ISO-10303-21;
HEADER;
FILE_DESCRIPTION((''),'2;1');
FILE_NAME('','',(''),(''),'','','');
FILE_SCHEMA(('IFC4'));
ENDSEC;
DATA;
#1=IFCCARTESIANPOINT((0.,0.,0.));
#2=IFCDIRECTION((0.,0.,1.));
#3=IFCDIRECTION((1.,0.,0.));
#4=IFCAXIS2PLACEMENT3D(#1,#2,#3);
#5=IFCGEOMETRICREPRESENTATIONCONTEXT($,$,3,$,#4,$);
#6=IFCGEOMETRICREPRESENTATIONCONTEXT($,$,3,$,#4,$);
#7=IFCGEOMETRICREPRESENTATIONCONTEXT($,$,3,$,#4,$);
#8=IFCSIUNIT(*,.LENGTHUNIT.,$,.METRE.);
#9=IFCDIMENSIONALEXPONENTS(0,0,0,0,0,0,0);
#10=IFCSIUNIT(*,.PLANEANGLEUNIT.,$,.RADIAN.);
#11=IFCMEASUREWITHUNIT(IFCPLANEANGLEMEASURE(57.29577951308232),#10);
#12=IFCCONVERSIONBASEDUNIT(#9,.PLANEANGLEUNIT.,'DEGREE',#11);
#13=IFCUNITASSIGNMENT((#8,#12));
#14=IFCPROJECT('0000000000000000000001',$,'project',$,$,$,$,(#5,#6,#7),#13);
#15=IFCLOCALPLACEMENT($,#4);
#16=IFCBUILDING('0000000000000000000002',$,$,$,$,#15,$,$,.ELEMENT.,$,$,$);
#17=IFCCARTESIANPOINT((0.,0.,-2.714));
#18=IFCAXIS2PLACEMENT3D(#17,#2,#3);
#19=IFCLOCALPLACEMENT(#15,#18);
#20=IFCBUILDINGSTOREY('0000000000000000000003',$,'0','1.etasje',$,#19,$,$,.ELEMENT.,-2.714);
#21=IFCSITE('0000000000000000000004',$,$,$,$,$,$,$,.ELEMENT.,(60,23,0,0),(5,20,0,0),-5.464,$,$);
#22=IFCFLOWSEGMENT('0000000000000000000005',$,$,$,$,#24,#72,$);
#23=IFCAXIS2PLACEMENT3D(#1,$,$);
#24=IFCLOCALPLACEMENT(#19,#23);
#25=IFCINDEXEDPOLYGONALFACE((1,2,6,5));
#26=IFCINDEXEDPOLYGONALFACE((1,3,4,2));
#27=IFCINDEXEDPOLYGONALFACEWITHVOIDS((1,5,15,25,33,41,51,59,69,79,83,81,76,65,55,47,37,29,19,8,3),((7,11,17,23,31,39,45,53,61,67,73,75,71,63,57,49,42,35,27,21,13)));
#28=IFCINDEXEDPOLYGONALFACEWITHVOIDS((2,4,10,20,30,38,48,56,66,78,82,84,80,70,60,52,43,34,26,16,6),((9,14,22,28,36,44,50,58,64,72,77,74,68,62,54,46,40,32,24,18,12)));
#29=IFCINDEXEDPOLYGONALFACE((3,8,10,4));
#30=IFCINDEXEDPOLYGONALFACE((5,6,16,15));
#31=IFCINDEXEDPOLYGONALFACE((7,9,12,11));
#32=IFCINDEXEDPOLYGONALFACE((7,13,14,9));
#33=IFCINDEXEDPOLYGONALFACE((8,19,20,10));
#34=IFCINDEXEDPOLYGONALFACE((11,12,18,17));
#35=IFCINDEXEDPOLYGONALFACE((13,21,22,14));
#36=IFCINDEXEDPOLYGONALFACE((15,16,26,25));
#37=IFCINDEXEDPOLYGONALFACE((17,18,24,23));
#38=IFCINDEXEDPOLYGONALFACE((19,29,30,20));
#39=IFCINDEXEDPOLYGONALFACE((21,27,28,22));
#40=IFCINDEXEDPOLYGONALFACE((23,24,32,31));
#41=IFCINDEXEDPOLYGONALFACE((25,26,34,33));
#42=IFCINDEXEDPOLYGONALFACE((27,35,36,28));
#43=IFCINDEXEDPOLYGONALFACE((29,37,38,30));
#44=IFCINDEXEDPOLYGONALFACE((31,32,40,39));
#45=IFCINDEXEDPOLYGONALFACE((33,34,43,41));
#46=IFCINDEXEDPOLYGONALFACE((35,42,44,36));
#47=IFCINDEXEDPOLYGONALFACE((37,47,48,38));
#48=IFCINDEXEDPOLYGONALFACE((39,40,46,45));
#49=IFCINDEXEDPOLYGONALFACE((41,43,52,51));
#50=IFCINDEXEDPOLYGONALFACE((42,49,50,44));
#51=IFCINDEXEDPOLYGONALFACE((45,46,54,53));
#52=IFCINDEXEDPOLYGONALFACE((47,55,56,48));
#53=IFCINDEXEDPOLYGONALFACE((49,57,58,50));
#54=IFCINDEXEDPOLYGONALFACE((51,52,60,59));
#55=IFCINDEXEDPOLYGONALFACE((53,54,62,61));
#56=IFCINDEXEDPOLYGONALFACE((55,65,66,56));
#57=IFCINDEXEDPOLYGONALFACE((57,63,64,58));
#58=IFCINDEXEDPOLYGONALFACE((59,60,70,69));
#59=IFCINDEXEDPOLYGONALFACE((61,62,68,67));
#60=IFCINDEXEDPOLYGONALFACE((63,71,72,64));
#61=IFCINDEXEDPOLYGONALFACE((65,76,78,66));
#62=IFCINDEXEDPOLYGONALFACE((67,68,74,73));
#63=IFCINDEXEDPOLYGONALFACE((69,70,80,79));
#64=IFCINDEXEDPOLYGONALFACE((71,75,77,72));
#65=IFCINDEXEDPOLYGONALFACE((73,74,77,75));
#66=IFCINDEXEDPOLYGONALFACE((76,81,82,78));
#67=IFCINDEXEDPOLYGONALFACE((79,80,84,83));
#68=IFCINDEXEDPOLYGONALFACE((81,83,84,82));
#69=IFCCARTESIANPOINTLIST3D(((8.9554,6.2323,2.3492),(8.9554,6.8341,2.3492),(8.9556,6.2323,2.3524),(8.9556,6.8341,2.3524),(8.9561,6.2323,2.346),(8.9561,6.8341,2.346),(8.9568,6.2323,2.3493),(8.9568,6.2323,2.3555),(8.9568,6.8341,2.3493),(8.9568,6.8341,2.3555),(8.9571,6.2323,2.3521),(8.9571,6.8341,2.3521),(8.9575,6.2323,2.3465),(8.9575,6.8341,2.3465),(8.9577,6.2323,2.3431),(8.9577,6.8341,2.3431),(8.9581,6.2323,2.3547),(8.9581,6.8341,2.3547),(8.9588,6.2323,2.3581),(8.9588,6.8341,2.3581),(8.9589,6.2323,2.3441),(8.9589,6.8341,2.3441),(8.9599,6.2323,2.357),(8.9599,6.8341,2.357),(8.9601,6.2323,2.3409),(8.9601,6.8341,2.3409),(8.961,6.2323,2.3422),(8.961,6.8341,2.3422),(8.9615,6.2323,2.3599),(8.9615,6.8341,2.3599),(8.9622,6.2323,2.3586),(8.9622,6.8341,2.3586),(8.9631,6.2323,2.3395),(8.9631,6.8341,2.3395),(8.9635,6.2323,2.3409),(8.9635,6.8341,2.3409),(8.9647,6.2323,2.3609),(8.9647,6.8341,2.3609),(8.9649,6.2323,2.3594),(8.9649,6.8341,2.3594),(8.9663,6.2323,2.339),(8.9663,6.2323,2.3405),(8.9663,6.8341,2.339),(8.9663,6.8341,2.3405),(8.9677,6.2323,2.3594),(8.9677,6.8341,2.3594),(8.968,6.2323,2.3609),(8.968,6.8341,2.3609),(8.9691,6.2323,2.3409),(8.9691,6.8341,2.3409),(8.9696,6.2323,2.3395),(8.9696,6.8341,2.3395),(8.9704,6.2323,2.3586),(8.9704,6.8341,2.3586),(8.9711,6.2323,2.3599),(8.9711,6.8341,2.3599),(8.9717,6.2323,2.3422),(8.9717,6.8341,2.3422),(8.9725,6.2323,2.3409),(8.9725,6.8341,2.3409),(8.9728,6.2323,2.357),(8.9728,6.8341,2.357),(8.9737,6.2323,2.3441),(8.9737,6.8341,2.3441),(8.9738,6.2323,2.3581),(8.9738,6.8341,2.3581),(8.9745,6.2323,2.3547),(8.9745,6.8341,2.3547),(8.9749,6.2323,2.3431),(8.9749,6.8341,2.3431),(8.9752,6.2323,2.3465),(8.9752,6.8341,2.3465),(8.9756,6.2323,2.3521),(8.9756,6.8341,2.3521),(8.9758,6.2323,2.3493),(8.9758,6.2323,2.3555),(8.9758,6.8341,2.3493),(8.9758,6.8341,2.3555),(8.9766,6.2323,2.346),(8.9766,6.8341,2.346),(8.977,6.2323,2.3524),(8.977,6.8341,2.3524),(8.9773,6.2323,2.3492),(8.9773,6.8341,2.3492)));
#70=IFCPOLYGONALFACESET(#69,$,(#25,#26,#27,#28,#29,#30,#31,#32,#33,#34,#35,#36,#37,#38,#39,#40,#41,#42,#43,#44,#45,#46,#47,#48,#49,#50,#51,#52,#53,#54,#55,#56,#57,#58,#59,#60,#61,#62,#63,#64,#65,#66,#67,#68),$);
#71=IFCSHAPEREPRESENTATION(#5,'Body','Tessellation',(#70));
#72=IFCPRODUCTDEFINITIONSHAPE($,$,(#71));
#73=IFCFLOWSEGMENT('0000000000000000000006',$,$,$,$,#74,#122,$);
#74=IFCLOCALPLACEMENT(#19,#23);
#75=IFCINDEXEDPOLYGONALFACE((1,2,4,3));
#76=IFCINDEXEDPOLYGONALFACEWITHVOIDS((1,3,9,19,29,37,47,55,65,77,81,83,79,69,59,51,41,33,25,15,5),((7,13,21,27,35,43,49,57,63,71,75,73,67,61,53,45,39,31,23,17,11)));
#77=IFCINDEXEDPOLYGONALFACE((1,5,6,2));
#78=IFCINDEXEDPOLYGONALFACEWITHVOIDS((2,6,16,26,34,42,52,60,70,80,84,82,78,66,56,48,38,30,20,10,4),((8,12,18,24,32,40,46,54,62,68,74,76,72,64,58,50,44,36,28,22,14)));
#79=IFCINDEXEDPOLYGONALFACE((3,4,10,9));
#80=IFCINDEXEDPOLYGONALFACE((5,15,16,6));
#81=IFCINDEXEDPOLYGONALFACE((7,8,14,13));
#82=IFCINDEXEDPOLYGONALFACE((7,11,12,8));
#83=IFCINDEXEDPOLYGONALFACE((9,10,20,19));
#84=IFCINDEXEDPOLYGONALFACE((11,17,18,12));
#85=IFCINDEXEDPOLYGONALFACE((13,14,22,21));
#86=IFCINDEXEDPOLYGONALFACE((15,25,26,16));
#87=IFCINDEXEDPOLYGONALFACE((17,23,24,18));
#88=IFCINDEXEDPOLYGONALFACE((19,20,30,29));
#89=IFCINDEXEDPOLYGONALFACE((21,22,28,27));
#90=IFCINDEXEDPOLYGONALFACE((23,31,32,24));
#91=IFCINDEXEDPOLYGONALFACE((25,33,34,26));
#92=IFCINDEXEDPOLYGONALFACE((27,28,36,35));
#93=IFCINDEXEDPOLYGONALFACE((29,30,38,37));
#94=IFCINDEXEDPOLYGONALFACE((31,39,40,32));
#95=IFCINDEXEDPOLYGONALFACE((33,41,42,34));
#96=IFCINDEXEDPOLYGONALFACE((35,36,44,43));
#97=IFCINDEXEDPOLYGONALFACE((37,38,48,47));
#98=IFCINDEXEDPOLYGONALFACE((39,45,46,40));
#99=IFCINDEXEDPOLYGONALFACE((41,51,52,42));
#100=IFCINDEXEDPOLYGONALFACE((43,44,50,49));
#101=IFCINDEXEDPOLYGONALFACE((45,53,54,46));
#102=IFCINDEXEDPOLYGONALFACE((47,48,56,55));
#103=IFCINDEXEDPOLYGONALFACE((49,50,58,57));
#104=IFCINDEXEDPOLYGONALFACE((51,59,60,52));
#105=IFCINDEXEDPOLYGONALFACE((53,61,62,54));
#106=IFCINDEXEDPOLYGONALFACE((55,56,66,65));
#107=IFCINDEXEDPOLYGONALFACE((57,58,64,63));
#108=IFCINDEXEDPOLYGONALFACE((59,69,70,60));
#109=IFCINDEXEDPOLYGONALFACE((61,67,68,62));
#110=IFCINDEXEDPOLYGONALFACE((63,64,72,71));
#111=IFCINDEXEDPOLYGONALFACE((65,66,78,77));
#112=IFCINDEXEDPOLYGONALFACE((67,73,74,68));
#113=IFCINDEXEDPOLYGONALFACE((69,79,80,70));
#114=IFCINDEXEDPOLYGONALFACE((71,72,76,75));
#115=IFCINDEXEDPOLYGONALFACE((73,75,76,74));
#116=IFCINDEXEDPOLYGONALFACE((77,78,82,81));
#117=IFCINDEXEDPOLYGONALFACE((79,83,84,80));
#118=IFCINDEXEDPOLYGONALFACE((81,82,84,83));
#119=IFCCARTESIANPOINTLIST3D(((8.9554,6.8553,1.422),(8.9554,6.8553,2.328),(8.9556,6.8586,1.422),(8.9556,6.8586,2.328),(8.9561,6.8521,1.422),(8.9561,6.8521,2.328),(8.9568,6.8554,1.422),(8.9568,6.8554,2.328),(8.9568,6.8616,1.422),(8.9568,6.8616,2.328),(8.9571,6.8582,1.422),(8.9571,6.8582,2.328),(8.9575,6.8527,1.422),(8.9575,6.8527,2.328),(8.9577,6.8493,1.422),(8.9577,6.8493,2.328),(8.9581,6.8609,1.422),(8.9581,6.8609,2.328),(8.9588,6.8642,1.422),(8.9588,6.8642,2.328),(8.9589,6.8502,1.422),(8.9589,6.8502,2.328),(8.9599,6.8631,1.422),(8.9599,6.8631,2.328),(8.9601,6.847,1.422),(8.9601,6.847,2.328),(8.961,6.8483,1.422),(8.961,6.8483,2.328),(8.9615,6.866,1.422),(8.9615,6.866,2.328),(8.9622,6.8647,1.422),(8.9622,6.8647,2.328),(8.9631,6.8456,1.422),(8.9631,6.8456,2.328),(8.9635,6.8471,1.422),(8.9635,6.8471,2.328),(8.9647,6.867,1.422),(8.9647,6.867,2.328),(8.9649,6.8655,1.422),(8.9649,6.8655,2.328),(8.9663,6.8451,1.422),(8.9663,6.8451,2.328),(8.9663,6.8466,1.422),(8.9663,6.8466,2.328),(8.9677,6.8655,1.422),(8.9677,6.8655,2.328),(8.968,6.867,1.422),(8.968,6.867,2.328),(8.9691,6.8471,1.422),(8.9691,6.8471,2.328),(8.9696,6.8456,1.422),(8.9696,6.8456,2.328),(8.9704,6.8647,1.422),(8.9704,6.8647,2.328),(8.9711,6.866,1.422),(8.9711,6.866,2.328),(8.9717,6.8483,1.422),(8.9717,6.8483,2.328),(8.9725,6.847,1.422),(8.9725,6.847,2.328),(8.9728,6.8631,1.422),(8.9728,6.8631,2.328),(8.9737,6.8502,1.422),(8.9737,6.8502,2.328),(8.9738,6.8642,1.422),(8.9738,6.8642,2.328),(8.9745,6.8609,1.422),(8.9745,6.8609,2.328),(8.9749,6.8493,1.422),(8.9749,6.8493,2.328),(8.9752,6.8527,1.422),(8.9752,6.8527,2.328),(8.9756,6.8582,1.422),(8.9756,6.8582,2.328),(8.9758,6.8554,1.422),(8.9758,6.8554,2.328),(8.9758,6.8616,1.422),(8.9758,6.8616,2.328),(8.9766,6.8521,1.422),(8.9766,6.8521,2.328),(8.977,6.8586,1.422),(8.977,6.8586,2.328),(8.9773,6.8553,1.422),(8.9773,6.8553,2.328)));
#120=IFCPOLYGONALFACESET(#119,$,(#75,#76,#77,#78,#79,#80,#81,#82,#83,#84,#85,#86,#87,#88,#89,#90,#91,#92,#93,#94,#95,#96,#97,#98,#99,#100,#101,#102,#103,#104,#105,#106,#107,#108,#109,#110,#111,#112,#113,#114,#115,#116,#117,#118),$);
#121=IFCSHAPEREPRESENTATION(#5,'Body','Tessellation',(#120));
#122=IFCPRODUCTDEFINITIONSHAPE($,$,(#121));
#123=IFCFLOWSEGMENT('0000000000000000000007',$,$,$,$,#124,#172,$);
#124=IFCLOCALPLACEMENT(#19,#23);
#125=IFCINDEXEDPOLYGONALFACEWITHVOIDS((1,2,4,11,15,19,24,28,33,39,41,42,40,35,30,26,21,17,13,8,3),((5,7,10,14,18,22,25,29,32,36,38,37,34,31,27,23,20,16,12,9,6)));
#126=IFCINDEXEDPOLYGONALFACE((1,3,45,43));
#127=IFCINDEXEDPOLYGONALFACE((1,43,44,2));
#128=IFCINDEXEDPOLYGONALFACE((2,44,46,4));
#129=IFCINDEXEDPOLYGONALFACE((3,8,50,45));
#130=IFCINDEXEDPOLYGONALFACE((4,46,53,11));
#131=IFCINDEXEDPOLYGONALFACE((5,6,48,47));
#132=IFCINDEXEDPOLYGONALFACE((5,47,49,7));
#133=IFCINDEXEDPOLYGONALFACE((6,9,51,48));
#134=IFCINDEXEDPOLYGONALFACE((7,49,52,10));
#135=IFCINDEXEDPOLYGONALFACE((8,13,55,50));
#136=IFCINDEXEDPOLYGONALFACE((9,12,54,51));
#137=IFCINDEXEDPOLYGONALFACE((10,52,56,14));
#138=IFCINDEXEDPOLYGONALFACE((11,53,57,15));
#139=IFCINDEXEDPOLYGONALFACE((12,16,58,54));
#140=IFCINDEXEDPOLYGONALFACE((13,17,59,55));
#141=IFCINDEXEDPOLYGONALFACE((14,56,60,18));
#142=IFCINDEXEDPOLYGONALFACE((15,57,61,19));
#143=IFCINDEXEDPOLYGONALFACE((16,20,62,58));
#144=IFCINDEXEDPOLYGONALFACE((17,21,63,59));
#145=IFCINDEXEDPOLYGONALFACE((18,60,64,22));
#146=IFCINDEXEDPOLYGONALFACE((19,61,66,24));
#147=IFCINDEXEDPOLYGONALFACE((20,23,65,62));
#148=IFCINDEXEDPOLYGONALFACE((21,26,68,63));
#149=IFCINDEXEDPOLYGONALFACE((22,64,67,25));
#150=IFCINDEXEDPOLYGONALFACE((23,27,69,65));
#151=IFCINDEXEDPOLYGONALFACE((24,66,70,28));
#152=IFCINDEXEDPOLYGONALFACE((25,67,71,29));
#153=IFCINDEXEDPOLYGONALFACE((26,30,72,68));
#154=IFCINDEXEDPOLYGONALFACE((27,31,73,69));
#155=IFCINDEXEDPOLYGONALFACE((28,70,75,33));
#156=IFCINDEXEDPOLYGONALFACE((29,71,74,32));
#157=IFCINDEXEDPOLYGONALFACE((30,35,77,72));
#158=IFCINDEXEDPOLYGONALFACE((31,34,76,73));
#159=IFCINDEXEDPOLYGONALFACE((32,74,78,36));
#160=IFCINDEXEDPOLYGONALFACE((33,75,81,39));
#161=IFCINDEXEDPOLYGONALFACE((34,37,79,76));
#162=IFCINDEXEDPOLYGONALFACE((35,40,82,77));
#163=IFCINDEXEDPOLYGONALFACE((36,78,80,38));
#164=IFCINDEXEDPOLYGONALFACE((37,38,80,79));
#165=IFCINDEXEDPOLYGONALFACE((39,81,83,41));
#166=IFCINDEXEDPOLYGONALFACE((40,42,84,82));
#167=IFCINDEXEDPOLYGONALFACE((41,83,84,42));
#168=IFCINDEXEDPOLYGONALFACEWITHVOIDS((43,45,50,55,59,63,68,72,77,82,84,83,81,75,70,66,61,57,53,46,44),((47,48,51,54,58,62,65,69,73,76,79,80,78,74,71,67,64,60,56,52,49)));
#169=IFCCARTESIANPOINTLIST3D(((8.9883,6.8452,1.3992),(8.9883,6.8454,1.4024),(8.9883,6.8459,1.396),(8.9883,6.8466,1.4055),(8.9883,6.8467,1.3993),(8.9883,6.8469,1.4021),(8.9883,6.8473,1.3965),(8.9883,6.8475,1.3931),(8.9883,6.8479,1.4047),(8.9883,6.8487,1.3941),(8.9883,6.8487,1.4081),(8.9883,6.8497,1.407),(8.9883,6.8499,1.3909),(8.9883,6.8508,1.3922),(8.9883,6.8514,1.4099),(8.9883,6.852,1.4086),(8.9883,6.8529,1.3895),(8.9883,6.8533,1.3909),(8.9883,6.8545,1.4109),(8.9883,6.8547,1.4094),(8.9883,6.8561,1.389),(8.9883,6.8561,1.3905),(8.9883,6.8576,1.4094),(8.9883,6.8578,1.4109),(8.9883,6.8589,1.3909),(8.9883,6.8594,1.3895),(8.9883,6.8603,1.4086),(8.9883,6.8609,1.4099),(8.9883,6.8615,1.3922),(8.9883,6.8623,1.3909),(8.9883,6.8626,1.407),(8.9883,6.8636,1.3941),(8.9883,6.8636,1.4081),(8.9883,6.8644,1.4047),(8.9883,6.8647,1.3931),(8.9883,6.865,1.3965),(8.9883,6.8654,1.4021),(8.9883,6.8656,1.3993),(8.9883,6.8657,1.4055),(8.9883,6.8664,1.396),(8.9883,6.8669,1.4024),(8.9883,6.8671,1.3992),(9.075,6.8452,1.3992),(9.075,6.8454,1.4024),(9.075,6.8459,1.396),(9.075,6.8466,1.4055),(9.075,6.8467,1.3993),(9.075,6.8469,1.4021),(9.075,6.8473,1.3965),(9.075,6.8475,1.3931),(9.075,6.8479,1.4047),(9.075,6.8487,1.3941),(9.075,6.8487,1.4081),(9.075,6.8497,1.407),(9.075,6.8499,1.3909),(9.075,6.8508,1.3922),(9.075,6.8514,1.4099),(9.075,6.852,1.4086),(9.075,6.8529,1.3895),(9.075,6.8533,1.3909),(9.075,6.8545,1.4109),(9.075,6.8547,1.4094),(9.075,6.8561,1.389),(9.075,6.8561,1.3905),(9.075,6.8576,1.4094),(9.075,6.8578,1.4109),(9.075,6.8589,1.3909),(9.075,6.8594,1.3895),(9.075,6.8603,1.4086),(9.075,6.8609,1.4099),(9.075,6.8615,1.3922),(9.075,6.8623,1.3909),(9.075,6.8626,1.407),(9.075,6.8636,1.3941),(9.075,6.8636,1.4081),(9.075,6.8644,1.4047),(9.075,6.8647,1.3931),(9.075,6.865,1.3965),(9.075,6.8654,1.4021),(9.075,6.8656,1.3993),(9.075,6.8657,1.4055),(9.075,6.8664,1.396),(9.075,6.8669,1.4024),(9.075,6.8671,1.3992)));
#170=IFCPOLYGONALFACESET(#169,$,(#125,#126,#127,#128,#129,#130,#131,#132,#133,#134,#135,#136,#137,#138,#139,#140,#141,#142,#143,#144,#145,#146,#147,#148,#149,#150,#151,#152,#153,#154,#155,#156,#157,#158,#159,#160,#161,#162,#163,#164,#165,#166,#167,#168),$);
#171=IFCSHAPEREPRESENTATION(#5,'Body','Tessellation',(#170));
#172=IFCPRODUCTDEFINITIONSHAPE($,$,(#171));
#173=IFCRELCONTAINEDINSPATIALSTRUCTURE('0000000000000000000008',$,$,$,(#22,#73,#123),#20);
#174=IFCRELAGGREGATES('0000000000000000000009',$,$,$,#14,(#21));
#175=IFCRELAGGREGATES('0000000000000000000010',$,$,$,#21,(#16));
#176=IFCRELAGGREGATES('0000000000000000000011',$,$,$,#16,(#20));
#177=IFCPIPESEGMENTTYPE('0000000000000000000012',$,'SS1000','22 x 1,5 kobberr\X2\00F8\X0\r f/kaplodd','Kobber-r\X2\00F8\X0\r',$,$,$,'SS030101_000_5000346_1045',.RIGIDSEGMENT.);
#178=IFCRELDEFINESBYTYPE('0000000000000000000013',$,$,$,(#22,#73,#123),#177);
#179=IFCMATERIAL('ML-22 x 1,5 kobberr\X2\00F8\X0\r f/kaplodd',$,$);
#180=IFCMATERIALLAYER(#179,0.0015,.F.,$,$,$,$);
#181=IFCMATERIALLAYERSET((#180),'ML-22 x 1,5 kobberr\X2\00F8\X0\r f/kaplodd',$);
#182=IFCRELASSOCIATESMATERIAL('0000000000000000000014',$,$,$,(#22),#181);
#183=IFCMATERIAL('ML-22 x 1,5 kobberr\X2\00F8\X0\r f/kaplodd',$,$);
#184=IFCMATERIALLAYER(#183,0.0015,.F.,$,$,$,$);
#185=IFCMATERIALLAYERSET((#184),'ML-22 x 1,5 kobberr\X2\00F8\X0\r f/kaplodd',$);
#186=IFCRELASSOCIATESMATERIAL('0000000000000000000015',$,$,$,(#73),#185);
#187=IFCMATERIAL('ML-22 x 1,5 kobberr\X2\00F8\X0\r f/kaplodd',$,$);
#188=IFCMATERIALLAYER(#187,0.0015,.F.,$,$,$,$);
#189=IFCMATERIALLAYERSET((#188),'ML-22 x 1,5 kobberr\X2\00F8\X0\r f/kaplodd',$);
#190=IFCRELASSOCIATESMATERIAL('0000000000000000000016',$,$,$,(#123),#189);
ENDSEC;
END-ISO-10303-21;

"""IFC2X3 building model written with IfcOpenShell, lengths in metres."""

from ifc_helpers import new_model, entity, si_unit, converted_unit, frame, origin_with_axes, origin_2d_with_axis, place, context, project, spatial, hollow_circle, extrude, material, layer, layer_set, layer_usage, type_object, element, save


model = new_model("IFC2X3")

# Units and contexts
context_of_model_1 = context(None, 3, world=origin_with_axes())
context_of_model_2 = context(None, 3, world=origin_with_axes())
context_of_model_3 = context(None, 3, world=origin_with_axes())
ifc_project = project(units=[si_unit("LENGTHUNIT", "METRE"), converted_unit("PLANEANGLEUNIT", "DEGREE", entity("IfcPlaneAngleMeasure", 57.29577951308232), si_unit("PLANEANGLEUNIT", "RADIAN"), dimensions=[0, 0, 0, 0, 0, 0, 0])], contexts=[context_of_model_1, context_of_model_2, context_of_model_3])

# Site, building, storey
site = spatial("IfcSite", under=ifc_project, CompositionType="ELEMENT", RefLatitude=(60, 23, 0, 0), RefLongitude=(5, 20, 0, 0), RefElevation=-5.464)
building_placement = place(None, origin_with_axes())
building = spatial("IfcBuilding", under=site, at=building_placement, CompositionType="ELEMENT")
storey_placement = place(building_placement, frame((0.0, 0.0, -2.714), z_axis=(0.0, 0.0, 1.0), x_axis=(1.0, 0.0, 0.0)))
storey = spatial("IfcBuildingStorey", under=building, at=storey_placement, Name="0", Description="1.etasje", CompositionType="ELEMENT", Elevation=-2.714)

# Flow segments
pipe_segment_type_1 = type_object("IfcPipeSegmentType", Name="SS1000", Description="22 x 1,5 kobberrør f/kaplodd", ApplicableOccurrence="Kobber-rør", ElementType="SS030101_000_5000346_1045", PredefinedType="RIGIDSEGMENT")
ifc_material_1 = material(Name="ML-22 x 1,5 kobberrør f/kaplodd")
ifc_layer_1 = layer(ifc_material_1, 0.0015, ventilated=False)
ifc_layer_set_1 = layer_set([ifc_layer_1], Name="ML-22 x 1,5 kobberrør f/kaplodd")
ifc_layer_usage_1 = layer_usage(ifc_layer_set_1, "AXIS2", "POSITIVE", 0.0)
flow_segment_1_placement = place(storey_placement, frame((8.9663, 6.2323, 2.35), z_axis=(0.0, 1.0, 0.0), x_axis=(0.0, 0.0, -1.0)))
element("IfcFlowSegment", 1, at=flow_segment_1_placement, inside=storey, type_object=pipe_segment_type_1, material=ifc_layer_usage_1, context=context_of_model_1, shape_type="SweptSolid", body=[
    extrude(hollow_circle(Radius=0.011, WallThickness=0.0015, at=origin_2d_with_axis()), origin_with_axes(), (0.0, 0.0, 1.0), 0.6019),
])
ifc_material_2 = material(Name="ML-22 x 1,5 kobberrør f/kaplodd")
ifc_layer_2 = layer(ifc_material_2, 0.0015, ventilated=False)
ifc_layer_set_2 = layer_set([ifc_layer_2], Name="ML-22 x 1,5 kobberrør f/kaplodd")
ifc_layer_usage_2 = layer_usage(ifc_layer_set_2, "AXIS2", "POSITIVE", 0.0)
flow_segment_2_placement = place(storey_placement, frame((8.9663, 6.8561, 2.328), z_axis=(0.0, 0.0, -1.0), x_axis=(0.0, -1.0, 0.0)))
element("IfcFlowSegment", 2, at=flow_segment_2_placement, inside=storey, type_object=pipe_segment_type_1, material=ifc_layer_usage_2, context=context_of_model_1, shape_type="SweptSolid", body=[
    extrude(hollow_circle(Radius=0.011, WallThickness=0.0015, at=origin_2d_with_axis()), origin_with_axes(), (0.0, 0.0, 1.0), 0.906),
])
ifc_material_3 = material(Name="ML-22 x 1,5 kobberrør f/kaplodd")
ifc_layer_3 = layer(ifc_material_3, 0.0015, ventilated=False)
ifc_layer_set_3 = layer_set([ifc_layer_3], Name="ML-22 x 1,5 kobberrør f/kaplodd")
ifc_layer_usage_3 = layer_usage(ifc_layer_set_3, "AXIS2", "POSITIVE", 0.0)
flow_segment_3_placement = place(storey_placement, frame((8.9883, 6.8561, 1.4), z_axis=(1.0, 0.0, 0.0), x_axis=(0.0, 0.0, -1.0)))
element("IfcFlowSegment", 3, at=flow_segment_3_placement, inside=storey, type_object=pipe_segment_type_1, material=ifc_layer_usage_3, context=context_of_model_1, shape_type="SweptSolid", body=[
    extrude(hollow_circle(Radius=0.011, WallThickness=0.0015, at=origin_2d_with_axis()), origin_with_axes(), (0.0, 0.0, 1.0), 0.0867),
])

save(model, "model.ifc")
